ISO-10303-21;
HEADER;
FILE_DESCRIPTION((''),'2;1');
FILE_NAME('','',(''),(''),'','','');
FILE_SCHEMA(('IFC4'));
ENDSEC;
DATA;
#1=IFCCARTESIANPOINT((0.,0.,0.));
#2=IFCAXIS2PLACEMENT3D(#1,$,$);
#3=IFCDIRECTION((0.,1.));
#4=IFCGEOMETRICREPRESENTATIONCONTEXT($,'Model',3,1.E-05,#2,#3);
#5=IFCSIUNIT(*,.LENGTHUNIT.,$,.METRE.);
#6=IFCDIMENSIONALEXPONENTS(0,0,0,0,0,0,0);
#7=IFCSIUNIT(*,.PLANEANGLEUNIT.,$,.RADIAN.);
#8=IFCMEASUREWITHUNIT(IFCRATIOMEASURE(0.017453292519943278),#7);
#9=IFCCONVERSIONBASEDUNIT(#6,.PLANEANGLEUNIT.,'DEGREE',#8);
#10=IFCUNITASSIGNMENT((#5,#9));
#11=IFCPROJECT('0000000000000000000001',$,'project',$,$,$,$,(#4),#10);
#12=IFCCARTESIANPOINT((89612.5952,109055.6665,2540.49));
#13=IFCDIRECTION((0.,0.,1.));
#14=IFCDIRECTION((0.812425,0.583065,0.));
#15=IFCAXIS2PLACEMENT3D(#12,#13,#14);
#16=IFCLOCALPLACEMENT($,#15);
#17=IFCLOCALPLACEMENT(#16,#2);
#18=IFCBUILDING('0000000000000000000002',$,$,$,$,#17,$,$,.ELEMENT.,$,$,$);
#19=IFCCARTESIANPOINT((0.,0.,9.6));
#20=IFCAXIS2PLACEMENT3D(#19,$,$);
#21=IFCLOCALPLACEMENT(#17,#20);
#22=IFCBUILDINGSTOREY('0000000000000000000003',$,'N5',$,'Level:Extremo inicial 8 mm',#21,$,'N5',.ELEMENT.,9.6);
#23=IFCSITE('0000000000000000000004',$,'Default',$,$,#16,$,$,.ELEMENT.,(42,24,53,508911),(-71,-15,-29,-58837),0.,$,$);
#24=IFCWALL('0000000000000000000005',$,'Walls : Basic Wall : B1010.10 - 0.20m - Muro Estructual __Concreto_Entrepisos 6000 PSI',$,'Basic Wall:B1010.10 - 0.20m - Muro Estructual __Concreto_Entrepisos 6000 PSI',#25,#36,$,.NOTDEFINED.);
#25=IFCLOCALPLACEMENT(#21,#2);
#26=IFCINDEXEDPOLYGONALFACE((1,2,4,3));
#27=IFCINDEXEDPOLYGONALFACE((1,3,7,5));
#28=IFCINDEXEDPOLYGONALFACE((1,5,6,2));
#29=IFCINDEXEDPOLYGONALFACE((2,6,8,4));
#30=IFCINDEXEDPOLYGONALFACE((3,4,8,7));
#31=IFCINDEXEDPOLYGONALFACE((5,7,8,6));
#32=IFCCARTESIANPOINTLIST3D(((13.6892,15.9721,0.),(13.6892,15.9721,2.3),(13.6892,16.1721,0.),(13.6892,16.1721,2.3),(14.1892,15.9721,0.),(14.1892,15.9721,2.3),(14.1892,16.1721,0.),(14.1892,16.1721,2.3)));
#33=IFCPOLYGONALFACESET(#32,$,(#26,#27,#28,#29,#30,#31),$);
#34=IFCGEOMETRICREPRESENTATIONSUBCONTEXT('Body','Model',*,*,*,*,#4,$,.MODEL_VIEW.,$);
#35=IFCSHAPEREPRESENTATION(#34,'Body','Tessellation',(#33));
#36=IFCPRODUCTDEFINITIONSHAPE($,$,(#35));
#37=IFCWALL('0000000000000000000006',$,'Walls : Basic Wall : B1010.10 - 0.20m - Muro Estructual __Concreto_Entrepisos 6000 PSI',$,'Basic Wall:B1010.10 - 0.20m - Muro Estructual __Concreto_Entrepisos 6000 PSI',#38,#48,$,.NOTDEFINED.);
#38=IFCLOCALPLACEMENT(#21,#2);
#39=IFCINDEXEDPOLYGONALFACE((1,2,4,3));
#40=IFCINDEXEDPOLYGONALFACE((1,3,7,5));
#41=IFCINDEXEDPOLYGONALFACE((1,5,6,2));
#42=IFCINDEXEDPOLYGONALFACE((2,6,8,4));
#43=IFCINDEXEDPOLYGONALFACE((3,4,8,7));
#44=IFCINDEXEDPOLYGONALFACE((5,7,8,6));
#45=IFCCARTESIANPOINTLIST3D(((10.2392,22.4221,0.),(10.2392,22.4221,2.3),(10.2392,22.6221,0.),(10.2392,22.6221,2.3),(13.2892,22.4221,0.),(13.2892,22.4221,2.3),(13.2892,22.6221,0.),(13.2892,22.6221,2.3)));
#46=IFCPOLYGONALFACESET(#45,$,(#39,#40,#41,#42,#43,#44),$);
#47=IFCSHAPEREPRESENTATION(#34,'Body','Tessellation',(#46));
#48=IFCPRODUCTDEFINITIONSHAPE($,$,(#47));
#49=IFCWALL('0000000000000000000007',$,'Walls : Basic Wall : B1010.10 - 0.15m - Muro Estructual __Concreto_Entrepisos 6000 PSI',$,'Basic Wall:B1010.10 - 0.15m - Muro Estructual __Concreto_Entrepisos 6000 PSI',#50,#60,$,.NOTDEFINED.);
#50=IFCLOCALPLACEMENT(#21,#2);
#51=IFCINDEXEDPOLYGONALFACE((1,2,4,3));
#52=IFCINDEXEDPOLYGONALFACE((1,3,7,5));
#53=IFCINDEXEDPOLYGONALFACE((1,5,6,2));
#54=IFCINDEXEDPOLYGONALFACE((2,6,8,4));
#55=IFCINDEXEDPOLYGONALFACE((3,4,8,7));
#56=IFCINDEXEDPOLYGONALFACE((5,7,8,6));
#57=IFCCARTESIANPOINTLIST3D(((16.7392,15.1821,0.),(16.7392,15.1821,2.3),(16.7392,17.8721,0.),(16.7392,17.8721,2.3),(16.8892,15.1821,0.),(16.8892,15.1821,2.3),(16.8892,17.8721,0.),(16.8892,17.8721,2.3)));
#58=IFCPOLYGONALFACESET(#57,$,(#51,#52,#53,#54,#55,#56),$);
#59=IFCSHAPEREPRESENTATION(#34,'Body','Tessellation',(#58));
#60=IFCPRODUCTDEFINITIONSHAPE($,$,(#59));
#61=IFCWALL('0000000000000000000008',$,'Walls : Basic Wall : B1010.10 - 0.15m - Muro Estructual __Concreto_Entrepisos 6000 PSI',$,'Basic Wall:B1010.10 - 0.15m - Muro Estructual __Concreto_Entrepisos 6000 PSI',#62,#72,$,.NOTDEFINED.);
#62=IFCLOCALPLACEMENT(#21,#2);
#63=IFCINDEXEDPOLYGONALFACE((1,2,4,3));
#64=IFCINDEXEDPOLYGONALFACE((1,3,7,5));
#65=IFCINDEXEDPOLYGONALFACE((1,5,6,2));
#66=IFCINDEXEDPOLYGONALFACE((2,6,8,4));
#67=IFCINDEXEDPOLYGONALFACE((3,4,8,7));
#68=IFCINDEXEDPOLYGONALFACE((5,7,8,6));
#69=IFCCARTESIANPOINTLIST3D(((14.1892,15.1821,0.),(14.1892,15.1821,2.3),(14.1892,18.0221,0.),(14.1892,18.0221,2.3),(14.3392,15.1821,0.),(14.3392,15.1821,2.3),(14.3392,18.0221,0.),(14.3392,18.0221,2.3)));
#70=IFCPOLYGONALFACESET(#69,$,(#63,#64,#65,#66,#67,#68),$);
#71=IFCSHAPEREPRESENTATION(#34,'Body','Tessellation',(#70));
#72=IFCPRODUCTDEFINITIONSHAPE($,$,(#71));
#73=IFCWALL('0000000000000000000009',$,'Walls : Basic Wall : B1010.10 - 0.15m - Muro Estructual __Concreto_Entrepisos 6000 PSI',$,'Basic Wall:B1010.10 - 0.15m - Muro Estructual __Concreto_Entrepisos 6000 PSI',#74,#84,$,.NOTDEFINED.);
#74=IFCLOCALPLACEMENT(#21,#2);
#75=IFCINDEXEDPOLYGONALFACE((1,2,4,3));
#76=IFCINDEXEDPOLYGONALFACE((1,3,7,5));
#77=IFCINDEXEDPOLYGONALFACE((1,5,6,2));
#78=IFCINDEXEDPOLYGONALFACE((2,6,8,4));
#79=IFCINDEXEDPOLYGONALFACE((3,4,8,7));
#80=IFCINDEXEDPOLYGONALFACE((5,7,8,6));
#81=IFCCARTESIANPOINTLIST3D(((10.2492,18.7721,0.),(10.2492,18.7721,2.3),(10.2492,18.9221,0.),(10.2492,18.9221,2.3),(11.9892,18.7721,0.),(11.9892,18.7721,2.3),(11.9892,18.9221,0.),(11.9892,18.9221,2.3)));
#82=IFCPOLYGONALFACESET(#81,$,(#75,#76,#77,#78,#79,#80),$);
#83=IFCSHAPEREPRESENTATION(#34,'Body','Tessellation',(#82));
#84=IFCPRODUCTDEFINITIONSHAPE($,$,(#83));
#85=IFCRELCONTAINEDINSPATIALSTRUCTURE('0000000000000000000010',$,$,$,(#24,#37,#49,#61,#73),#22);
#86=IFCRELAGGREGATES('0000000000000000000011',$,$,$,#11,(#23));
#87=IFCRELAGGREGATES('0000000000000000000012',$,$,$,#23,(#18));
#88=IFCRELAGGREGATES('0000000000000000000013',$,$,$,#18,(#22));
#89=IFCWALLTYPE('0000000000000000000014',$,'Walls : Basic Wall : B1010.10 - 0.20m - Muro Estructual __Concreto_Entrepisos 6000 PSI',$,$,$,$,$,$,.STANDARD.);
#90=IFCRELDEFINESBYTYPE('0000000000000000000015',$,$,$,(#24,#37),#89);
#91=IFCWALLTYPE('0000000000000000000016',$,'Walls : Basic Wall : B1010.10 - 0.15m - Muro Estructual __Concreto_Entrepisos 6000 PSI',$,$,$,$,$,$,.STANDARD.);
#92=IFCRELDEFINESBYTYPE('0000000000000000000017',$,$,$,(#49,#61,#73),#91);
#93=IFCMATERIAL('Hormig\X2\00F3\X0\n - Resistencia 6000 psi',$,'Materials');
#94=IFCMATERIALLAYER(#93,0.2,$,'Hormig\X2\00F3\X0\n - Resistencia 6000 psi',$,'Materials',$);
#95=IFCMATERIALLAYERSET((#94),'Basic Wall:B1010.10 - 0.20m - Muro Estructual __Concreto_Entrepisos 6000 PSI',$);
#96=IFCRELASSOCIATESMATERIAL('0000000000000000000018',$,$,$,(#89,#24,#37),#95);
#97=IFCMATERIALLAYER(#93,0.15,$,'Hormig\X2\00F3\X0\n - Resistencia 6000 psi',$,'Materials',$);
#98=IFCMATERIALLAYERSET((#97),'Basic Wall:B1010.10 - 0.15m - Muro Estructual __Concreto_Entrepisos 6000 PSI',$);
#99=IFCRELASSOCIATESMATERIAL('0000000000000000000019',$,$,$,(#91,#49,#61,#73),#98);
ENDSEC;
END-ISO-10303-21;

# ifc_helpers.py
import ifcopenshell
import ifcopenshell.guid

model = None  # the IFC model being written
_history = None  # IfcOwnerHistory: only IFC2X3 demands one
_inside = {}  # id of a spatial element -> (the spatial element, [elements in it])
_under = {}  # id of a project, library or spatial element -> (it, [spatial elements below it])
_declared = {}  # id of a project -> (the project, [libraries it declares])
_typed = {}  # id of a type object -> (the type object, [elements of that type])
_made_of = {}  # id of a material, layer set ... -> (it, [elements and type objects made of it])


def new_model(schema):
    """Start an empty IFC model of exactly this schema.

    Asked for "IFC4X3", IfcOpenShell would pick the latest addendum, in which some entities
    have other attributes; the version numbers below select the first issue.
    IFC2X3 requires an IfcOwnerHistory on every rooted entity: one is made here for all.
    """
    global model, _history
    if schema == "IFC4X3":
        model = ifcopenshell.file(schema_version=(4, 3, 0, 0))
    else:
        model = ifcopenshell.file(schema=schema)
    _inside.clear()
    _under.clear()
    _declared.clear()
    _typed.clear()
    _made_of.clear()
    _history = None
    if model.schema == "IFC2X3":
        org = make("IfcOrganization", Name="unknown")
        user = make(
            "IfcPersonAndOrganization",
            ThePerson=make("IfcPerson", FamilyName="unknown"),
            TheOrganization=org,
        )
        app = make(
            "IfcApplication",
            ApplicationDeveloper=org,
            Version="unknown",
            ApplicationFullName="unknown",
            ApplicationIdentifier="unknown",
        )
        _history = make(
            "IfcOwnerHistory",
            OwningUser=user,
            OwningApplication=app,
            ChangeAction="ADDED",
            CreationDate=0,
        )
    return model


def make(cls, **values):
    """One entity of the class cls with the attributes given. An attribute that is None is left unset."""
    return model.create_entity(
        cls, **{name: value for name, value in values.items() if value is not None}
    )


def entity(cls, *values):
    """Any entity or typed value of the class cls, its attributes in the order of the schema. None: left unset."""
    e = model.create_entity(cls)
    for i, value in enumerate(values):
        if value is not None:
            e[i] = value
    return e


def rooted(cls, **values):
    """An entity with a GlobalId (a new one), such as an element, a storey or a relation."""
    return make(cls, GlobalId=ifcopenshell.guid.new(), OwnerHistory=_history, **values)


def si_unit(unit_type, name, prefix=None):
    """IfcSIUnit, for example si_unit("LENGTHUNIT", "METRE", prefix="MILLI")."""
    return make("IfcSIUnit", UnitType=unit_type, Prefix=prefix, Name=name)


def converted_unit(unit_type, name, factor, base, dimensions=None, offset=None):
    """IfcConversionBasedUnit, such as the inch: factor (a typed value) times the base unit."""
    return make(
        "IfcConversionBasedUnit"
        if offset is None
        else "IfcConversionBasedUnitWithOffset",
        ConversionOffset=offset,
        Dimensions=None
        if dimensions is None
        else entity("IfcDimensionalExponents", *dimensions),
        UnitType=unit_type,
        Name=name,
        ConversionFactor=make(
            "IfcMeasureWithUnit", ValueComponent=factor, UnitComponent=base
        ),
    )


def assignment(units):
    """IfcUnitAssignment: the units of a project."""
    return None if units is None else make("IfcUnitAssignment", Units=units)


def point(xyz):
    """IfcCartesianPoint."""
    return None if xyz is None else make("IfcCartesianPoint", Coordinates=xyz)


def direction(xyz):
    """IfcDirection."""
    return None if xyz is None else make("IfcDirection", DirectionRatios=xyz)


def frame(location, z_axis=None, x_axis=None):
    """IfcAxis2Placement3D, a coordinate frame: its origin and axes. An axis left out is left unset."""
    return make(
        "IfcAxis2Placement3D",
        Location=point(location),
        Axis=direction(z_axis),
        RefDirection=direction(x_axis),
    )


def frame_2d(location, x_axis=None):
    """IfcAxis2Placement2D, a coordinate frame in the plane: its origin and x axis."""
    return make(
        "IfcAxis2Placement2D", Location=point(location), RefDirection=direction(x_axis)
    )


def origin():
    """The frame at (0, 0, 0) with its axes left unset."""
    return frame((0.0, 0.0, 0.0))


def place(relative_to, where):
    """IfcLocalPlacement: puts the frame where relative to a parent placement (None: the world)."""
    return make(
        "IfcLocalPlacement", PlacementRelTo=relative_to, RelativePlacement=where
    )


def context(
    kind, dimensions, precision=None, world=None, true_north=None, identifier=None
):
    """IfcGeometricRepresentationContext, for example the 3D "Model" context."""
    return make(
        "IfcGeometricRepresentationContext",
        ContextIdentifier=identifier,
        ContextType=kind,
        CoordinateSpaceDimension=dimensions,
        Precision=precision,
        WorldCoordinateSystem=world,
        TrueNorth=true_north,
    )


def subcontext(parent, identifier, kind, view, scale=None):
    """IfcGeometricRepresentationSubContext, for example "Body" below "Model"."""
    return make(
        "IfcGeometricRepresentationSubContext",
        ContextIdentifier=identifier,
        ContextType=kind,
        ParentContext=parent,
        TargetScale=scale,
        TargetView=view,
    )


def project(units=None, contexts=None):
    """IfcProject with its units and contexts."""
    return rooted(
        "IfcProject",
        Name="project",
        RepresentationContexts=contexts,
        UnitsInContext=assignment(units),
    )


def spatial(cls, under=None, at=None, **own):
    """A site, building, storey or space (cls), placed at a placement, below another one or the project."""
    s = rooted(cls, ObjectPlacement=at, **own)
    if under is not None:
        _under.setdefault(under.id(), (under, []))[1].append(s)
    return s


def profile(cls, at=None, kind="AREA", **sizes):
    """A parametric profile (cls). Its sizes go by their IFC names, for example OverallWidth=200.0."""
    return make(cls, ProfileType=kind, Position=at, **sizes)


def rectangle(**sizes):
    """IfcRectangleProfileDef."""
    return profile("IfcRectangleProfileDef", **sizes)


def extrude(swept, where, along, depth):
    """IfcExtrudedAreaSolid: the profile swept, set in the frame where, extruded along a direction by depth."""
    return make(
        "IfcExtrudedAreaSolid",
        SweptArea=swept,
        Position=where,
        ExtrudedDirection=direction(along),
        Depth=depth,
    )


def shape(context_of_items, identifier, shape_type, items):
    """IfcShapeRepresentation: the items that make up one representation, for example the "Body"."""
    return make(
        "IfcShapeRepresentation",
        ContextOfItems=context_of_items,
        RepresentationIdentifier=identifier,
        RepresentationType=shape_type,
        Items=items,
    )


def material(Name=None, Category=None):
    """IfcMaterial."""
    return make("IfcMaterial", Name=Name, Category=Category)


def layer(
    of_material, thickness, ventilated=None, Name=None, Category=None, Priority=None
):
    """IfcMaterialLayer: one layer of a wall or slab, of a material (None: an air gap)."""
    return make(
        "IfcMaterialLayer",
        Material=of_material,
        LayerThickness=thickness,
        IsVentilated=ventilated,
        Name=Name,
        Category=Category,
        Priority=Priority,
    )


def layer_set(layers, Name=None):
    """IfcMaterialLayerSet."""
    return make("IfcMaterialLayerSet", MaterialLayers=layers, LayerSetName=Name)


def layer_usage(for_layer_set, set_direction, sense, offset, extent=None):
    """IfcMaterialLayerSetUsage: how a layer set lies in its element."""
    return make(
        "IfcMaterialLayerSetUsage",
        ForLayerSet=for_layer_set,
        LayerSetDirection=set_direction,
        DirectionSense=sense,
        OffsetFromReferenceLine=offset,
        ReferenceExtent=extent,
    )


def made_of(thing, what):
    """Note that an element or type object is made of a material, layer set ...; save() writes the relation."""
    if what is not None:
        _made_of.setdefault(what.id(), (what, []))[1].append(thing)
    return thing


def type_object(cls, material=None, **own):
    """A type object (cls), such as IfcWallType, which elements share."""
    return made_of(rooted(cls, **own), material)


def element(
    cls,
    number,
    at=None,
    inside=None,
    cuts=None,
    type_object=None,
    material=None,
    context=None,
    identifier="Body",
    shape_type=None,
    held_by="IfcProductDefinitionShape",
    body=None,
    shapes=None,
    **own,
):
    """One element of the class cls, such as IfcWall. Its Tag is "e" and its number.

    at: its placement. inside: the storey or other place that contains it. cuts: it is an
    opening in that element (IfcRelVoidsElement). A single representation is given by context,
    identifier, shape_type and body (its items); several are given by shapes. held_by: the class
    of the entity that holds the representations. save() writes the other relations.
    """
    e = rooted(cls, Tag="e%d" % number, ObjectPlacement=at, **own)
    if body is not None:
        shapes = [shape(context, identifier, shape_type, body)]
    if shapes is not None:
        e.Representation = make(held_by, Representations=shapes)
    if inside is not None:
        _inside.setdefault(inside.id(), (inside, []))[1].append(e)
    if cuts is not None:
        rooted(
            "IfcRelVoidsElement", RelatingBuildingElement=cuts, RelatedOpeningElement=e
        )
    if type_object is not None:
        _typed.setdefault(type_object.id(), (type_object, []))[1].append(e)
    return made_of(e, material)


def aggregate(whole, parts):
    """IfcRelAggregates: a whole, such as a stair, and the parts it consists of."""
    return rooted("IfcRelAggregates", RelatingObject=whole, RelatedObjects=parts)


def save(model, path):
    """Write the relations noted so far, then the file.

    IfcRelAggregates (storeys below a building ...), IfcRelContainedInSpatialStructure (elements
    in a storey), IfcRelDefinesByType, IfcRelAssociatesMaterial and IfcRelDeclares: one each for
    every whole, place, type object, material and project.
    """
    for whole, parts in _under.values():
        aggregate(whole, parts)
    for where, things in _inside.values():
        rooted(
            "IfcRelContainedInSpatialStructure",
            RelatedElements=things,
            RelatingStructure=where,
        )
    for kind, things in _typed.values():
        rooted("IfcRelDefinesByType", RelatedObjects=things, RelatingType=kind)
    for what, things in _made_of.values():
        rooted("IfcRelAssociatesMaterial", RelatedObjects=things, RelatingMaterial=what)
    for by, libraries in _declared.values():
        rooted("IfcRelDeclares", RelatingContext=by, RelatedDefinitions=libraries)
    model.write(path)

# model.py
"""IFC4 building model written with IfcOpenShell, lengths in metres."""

from ifc_helpers import new_model, entity, si_unit, converted_unit, direction, frame, frame_2d, origin, place, context, subcontext, project, spatial, rectangle, extrude, material, layer, layer_set, layer_usage, type_object, element, save


model = new_model("IFC4")

# Units and contexts
model_context = context("Model", 3, precision=1e-05, world=origin(), true_north=direction((0.0, 1.0)))
body_context = subcontext(model_context, "Body", "Model", "MODEL_VIEW")
ifc_project = project(units=[si_unit("LENGTHUNIT", "METRE"), converted_unit("PLANEANGLEUNIT", "DEGREE", entity("IfcRatioMeasure", 0.017453292519943278), si_unit("PLANEANGLEUNIT", "RADIAN"), dimensions=[0, 0, 0, 0, 0, 0, 0])], contexts=[model_context])

# Site, building, storey
site_placement = place(None, frame((89612.5952, 109055.6665, 2540.49), z_axis=(0.0, 0.0, 1.0), x_axis=(0.812425, 0.583065, 0.0)))
site = spatial("IfcSite", under=ifc_project, at=site_placement, Name="Default", CompositionType="ELEMENT", RefLatitude=(42, 24, 53, 508911), RefLongitude=(-71, -15, -29, -58837), RefElevation=0.0)
building_placement = place(site_placement, origin())
building = spatial("IfcBuilding", under=site, at=building_placement, CompositionType="ELEMENT")
storey_placement = place(building_placement, frame((0.0, 0.0, 9.6)))
storey = spatial("IfcBuildingStorey", under=building, at=storey_placement, Name="N5", ObjectType="Level:Extremo inicial 8 mm", LongName="N5", CompositionType="ELEMENT", Elevation=9.6)

# Walls
ifc_material_1 = material(Name="Hormigón - Resistencia 6000 psi", Category="Materials")
ifc_layer_1 = layer(ifc_material_1, 0.2, Name="Hormigón - Resistencia 6000 psi", Category="Materials")
ifc_layer_set_1 = layer_set([ifc_layer_1], Name="Basic Wall:B1010.10 - 0.20m - Muro Estructual __Concreto_Entrepisos 6000 PSI")
wall_type_1 = type_object("IfcWallType", Name="Walls : Basic Wall : B1010.10 - 0.20m - Muro Estructual __Concreto_Entrepisos 6000 PSI", PredefinedType="STANDARD", material=ifc_layer_set_1)
ifc_layer_usage_1 = layer_usage(ifc_layer_set_1, "AXIS2", "NEGATIVE", 0.1)
wall_1_placement = place(storey_placement, frame((13.6892, 16.0721, 0.0)))
element("IfcWall", 1, at=wall_1_placement, inside=storey, type_object=wall_type_1, material=ifc_layer_usage_1, Name="Walls : Basic Wall : B1010.10 - 0.20m - Muro Estructual __Concreto_Entrepisos 6000 PSI", ObjectType="Basic Wall:B1010.10 - 0.20m - Muro Estructual __Concreto_Entrepisos 6000 PSI", PredefinedType="NOTDEFINED", context=body_context, shape_type="SweptSolid", body=[
    extrude(rectangle(XDim=0.5, YDim=0.2, at=frame_2d((0.25, 0.0), x_axis=(-1.0, 0.0))), origin(), (0.0, 0.0, 1.0), 2.3),
])
ifc_layer_usage_2 = layer_usage(ifc_layer_set_1, "AXIS2", "POSITIVE", -0.1)
wall_2_placement = place(storey_placement, frame((10.2392, 22.5221, 0.0)))
element("IfcWall", 2, at=wall_2_placement, inside=storey, type_object=wall_type_1, material=ifc_layer_usage_2, Name="Walls : Basic Wall : B1010.10 - 0.20m - Muro Estructual __Concreto_Entrepisos 6000 PSI", ObjectType="Basic Wall:B1010.10 - 0.20m - Muro Estructual __Concreto_Entrepisos 6000 PSI", PredefinedType="NOTDEFINED", context=body_context, shape_type="SweptSolid", body=[
    extrude(rectangle(XDim=3.05, YDim=0.2, at=frame_2d((1.525, 0.0), x_axis=(-1.0, 0.0))), origin(), (0.0, 0.0, 1.0), 2.3),
])
ifc_layer_2 = layer(ifc_material_1, 0.15, Name="Hormigón - Resistencia 6000 psi", Category="Materials")
ifc_layer_set_2 = layer_set([ifc_layer_2], Name="Basic Wall:B1010.10 - 0.15m - Muro Estructual __Concreto_Entrepisos 6000 PSI")
ifc_layer_usage_3 = layer_usage(ifc_layer_set_2, "AXIS2", "NEGATIVE", 0.075)
wall_type_2 = type_object("IfcWallType", Name="Walls : Basic Wall : B1010.10 - 0.15m - Muro Estructual __Concreto_Entrepisos 6000 PSI", PredefinedType="STANDARD", material=ifc_layer_set_2)
wall_3_placement = place(storey_placement, frame((16.8142, 15.1821, 0.0), z_axis=(0.0, 0.0, 1.0), x_axis=(0.0, 1.0, 0.0)))
element("IfcWall", 3, at=wall_3_placement, inside=storey, type_object=wall_type_2, material=ifc_layer_usage_3, Name="Walls : Basic Wall : B1010.10 - 0.15m - Muro Estructual __Concreto_Entrepisos 6000 PSI", ObjectType="Basic Wall:B1010.10 - 0.15m - Muro Estructual __Concreto_Entrepisos 6000 PSI", PredefinedType="NOTDEFINED", context=body_context, shape_type="SweptSolid", body=[
    extrude(rectangle(XDim=2.69, YDim=0.15, at=frame_2d((1.345, 0.0), x_axis=(-1.0, 0.0))), origin(), (0.0, 0.0, 1.0), 2.3),
])
ifc_layer_usage_4 = layer_usage(ifc_layer_set_2, "AXIS2", "NEGATIVE", 0.075)
wall_4_placement = place(storey_placement, frame((14.2642, 15.1821, 0.0), z_axis=(0.0, 0.0, 1.0), x_axis=(0.0, 1.0, 0.0)))
element("IfcWall", 4, at=wall_4_placement, inside=storey, type_object=wall_type_2, material=ifc_layer_usage_4, Name="Walls : Basic Wall : B1010.10 - 0.15m - Muro Estructual __Concreto_Entrepisos 6000 PSI", ObjectType="Basic Wall:B1010.10 - 0.15m - Muro Estructual __Concreto_Entrepisos 6000 PSI", PredefinedType="NOTDEFINED", context=body_context, shape_type="SweptSolid", body=[
    extrude(rectangle(XDim=2.84, YDim=0.15, at=frame_2d((1.42, 0.0), x_axis=(-1.0, 0.0))), origin(), (0.0, 0.0, 1.0), 2.3),
])
ifc_layer_usage_5 = layer_usage(ifc_layer_set_2, "AXIS2", "NEGATIVE", 0.075)
wall_5_placement = place(storey_placement, frame((11.9892, 18.8471, 0.0), z_axis=(0.0, 0.0, 1.0), x_axis=(-1.0, 0.0, 0.0)))
element("IfcWall", 5, at=wall_5_placement, inside=storey, type_object=wall_type_2, material=ifc_layer_usage_5, Name="Walls : Basic Wall : B1010.10 - 0.15m - Muro Estructual __Concreto_Entrepisos 6000 PSI", ObjectType="Basic Wall:B1010.10 - 0.15m - Muro Estructual __Concreto_Entrepisos 6000 PSI", PredefinedType="NOTDEFINED", context=body_context, shape_type="SweptSolid", body=[
    extrude(rectangle(XDim=1.74, YDim=0.15, at=frame_2d((0.87, 0.0), x_axis=(-1.0, 0.0))), origin(), (0.0, 0.0, 1.0), 2.3),
])

save(model, "model.ifc")
